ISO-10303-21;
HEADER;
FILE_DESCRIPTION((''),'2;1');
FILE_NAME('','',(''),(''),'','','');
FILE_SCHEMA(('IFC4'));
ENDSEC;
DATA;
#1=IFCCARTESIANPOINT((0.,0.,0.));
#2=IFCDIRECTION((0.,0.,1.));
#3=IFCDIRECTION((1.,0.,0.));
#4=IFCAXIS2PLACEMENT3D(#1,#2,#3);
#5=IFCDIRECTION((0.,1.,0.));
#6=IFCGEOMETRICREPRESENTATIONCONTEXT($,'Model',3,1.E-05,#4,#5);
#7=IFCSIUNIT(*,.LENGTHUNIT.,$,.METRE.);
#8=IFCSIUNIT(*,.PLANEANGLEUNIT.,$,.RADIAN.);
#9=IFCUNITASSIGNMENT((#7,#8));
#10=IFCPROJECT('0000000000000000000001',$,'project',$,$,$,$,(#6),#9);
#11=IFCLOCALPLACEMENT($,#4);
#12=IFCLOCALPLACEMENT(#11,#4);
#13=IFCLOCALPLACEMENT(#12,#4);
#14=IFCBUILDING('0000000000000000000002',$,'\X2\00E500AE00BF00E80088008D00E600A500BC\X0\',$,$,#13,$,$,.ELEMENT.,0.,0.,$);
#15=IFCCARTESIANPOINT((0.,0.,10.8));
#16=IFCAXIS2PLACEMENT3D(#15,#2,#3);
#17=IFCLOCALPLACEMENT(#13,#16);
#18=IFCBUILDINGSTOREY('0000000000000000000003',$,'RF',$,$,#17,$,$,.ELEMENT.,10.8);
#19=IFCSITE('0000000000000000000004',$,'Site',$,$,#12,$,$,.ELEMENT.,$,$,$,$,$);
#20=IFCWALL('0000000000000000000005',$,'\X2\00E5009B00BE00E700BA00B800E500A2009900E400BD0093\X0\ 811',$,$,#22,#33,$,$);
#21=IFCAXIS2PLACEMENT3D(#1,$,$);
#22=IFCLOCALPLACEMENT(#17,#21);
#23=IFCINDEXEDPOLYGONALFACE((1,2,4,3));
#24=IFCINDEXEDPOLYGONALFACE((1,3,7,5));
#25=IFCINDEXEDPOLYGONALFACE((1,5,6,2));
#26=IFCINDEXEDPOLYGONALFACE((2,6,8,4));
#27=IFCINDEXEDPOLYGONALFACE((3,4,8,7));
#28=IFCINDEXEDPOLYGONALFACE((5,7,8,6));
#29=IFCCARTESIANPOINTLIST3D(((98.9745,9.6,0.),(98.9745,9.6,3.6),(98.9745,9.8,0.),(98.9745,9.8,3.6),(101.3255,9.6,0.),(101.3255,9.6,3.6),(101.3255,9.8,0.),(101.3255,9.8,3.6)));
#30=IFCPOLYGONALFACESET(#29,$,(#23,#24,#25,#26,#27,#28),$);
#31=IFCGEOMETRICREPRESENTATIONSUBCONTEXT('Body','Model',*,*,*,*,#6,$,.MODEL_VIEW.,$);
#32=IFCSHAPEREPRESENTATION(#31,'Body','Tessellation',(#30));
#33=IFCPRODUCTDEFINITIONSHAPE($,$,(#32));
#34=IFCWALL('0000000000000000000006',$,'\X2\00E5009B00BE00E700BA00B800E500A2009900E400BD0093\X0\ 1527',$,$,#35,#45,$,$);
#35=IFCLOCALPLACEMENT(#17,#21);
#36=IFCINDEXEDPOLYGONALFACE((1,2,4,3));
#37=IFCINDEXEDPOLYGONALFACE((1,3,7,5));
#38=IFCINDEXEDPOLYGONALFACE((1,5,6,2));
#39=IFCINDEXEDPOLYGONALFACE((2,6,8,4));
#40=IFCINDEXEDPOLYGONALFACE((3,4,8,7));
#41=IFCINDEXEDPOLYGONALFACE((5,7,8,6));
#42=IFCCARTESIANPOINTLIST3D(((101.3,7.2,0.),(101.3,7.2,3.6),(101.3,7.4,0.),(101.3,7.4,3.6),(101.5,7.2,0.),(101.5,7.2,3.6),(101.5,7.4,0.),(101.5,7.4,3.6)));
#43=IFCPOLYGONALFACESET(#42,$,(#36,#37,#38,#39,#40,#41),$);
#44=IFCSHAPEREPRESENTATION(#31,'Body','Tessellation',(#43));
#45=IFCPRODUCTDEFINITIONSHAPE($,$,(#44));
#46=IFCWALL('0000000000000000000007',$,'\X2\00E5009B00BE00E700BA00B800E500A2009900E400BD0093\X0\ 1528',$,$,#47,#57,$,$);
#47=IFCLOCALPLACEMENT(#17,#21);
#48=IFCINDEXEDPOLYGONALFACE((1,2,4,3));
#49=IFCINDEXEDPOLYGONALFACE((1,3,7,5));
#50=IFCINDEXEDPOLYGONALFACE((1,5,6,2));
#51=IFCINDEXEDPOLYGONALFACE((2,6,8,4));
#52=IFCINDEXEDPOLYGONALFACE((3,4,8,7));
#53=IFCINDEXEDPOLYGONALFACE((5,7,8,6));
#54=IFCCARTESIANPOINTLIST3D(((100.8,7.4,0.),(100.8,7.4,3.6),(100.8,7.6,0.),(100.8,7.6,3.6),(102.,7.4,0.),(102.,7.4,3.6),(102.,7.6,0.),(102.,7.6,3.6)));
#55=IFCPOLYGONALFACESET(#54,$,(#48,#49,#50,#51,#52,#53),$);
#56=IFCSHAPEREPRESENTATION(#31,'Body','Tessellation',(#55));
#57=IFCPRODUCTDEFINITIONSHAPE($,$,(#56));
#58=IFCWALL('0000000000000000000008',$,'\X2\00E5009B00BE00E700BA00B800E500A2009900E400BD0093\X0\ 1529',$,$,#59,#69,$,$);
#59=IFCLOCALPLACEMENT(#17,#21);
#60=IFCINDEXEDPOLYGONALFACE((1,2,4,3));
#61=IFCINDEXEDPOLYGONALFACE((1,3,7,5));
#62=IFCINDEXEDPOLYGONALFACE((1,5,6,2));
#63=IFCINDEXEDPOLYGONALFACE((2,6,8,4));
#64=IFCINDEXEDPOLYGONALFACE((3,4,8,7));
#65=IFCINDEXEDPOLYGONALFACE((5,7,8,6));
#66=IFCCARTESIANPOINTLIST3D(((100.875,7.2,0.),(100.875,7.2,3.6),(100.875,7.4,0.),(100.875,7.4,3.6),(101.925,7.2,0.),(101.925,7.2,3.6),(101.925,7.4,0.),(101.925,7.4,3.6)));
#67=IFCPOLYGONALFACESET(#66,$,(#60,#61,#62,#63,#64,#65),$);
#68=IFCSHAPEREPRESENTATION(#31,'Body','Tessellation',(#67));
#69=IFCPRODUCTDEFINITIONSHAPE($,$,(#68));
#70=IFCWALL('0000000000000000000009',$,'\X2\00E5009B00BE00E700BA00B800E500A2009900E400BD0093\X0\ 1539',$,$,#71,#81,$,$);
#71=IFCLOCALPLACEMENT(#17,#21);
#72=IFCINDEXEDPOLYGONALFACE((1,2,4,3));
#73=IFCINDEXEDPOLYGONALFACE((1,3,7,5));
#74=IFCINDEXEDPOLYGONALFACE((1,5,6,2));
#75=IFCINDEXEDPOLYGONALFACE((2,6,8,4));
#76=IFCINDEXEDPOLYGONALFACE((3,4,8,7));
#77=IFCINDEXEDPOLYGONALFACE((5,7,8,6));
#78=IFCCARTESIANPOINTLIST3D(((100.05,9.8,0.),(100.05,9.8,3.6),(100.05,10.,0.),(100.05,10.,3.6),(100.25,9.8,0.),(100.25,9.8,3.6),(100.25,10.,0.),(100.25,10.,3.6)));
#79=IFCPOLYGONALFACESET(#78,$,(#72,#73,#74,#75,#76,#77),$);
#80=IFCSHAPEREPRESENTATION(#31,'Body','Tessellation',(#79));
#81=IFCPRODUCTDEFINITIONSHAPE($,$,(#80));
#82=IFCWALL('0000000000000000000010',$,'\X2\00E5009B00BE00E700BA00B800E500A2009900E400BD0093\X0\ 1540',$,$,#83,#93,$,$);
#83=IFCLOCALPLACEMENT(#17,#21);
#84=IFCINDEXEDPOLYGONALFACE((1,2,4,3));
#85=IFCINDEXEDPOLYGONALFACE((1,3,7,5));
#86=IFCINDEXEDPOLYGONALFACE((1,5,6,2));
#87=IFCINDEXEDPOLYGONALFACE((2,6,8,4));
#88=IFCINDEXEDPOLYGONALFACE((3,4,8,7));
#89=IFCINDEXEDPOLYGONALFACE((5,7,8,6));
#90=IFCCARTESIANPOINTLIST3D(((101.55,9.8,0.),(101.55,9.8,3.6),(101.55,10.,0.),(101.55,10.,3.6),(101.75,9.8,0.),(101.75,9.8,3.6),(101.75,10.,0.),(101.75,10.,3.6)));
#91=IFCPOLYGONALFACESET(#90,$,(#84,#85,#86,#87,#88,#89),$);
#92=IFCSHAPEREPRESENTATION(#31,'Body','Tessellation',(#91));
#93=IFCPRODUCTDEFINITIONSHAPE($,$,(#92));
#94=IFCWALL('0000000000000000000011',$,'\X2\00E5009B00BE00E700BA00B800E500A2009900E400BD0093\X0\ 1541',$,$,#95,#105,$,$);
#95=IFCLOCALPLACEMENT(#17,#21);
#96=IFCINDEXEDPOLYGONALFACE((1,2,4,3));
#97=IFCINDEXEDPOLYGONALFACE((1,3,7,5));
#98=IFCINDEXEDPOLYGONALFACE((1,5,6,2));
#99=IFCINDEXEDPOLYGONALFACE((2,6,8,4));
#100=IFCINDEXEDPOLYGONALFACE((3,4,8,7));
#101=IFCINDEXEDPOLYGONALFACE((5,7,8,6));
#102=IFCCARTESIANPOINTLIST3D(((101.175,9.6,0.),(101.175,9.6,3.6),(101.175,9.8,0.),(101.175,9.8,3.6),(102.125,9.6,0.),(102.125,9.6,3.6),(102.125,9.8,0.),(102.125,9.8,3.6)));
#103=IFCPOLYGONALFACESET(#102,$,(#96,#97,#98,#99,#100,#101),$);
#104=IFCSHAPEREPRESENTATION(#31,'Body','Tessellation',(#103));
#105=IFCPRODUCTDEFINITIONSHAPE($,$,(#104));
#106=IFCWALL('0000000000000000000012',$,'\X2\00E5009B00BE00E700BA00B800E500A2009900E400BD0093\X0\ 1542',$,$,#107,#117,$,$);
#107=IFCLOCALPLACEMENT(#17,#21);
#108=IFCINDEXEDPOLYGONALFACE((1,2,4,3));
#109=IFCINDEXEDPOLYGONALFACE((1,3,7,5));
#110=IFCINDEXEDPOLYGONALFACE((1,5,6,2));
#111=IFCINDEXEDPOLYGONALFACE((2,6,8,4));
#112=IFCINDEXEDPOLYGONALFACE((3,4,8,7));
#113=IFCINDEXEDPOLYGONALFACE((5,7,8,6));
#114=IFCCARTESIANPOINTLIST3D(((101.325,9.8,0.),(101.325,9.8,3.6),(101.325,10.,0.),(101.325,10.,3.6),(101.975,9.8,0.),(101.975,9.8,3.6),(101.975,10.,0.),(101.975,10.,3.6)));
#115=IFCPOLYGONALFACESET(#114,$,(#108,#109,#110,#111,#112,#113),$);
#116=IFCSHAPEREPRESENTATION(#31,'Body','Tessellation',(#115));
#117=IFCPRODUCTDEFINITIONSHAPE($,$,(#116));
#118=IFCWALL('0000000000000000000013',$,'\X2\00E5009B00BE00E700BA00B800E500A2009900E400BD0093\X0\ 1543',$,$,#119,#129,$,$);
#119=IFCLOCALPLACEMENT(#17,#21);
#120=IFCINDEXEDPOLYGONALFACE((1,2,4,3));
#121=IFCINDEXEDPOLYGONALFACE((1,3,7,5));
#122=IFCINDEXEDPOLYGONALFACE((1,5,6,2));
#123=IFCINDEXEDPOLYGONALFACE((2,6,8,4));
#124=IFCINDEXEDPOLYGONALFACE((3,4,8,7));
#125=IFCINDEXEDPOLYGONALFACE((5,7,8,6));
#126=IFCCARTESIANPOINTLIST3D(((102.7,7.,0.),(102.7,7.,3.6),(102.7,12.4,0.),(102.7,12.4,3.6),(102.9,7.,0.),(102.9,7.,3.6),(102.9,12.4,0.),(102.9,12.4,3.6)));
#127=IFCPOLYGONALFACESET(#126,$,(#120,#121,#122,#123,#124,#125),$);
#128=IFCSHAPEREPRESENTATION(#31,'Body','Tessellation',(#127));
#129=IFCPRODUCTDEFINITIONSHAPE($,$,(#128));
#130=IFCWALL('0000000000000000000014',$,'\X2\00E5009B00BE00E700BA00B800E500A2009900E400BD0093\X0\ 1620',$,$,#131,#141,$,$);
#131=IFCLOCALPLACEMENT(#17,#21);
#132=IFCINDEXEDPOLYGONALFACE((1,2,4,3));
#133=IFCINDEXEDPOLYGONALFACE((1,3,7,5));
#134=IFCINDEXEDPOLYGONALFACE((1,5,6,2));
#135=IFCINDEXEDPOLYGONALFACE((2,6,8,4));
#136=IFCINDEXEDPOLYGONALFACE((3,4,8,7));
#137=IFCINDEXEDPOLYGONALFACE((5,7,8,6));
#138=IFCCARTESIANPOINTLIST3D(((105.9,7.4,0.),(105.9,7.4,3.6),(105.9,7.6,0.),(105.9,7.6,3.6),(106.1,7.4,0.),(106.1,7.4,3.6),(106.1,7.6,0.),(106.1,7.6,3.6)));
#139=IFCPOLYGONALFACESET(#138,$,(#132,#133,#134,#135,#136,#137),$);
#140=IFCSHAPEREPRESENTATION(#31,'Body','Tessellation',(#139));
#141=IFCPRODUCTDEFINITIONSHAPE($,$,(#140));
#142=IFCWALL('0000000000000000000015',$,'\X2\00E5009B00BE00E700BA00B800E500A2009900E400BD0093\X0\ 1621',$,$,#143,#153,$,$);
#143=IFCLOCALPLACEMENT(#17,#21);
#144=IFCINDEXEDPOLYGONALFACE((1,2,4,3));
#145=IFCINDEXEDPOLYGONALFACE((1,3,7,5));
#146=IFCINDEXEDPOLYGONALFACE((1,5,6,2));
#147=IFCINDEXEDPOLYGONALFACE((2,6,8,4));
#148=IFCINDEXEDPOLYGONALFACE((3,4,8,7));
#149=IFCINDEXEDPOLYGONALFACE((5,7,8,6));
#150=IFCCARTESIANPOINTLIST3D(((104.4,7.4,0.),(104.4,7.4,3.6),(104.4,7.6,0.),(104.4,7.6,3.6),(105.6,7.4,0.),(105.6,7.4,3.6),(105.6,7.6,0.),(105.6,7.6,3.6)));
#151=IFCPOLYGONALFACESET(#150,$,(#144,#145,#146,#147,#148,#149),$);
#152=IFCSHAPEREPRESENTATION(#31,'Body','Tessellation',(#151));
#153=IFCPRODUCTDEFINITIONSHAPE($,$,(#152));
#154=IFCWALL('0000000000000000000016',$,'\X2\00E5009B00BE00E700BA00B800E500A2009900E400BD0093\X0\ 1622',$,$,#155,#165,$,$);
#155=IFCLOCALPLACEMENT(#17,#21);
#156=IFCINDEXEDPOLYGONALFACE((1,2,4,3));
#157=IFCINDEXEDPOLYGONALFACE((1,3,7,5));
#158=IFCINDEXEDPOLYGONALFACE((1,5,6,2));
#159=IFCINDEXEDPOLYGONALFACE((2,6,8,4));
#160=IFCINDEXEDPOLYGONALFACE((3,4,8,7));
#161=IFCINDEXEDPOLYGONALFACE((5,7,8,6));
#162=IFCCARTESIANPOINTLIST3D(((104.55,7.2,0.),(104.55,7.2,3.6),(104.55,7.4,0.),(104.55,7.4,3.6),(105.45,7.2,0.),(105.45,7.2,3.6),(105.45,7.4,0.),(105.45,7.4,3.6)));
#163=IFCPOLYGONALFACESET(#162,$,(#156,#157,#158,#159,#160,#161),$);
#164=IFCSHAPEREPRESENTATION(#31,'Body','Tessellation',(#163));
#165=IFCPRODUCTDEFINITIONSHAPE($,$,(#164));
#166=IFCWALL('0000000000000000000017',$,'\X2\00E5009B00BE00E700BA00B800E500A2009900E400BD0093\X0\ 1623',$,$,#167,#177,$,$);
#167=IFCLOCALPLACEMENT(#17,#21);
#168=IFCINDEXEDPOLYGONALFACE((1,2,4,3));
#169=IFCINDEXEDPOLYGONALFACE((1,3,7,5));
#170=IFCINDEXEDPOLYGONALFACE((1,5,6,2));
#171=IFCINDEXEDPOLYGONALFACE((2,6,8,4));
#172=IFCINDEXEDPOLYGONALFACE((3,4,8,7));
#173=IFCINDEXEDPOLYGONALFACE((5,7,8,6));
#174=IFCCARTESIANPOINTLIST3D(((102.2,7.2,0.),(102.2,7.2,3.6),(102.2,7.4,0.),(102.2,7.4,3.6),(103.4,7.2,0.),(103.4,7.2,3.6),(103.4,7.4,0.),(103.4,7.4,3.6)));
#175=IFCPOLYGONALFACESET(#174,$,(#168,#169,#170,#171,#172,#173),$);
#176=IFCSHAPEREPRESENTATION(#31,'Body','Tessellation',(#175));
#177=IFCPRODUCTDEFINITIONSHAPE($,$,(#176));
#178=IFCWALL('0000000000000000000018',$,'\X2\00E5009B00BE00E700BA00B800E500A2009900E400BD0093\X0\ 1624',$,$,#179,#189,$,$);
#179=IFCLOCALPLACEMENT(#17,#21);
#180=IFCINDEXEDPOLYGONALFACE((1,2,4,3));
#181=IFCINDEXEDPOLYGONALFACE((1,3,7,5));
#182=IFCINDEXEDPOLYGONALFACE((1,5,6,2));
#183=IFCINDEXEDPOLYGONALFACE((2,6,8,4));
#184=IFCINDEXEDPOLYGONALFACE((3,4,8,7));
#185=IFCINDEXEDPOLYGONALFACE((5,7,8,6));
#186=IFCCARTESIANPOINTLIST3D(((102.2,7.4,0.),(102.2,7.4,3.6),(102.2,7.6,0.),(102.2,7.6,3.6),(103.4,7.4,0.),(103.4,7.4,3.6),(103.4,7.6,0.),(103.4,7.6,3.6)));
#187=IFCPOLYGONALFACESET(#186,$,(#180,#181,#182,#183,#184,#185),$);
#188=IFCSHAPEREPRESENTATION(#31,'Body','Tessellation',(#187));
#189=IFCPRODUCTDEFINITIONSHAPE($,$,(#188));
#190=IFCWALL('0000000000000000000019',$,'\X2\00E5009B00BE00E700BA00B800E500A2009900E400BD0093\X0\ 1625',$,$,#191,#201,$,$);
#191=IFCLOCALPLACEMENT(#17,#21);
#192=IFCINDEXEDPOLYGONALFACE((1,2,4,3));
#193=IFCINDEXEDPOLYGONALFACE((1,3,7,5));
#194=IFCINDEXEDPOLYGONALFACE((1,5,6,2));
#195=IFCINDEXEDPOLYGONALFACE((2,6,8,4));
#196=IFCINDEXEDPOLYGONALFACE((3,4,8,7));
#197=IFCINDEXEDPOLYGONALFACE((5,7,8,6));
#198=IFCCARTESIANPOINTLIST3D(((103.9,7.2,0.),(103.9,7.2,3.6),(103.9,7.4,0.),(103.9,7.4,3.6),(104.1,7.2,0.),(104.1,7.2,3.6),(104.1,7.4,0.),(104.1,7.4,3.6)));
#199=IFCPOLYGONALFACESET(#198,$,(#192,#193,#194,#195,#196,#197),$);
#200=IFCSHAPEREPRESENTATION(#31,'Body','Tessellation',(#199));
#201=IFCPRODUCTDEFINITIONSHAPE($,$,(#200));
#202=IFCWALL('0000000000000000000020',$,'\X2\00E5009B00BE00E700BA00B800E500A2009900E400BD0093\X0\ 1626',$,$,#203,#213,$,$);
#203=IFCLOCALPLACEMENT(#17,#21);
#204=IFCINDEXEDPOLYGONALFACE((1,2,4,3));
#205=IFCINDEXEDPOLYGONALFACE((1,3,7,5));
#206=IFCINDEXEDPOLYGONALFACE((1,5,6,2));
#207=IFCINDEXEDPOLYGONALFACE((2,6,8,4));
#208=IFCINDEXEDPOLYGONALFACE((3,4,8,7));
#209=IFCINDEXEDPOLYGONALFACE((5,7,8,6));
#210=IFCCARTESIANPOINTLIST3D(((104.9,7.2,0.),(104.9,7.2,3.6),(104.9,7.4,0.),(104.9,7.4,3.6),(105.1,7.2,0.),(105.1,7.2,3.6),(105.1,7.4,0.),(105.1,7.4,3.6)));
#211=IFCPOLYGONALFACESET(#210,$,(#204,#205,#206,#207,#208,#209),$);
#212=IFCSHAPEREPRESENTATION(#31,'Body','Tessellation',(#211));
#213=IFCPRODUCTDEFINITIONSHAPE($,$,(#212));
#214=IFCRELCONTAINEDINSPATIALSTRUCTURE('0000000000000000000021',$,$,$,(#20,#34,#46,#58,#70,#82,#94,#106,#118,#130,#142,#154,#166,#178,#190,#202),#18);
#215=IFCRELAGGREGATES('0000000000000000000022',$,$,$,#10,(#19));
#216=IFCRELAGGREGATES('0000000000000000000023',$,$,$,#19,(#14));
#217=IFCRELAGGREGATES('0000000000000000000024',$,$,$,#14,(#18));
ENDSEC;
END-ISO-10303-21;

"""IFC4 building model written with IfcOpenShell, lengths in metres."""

from ifc_helpers import new_model, si_unit, direction, frame, frame_2d, origin_with_axes, place, context, subcontext, project, spatial, rectangle, extrude, element, save


model = new_model("IFC4")

# Units and contexts
model_context = context("Model", 3, precision=1e-05, world=origin_with_axes(), true_north=direction((0.0, 1.0, 0.0)))
body_context = subcontext(model_context, "Body", "Model", "MODEL_VIEW")
ifc_project = project(units=[si_unit("LENGTHUNIT", "METRE"), si_unit("PLANEANGLEUNIT", "RADIAN")], contexts=[model_context])

# Site, building, storey
placement = place(None, origin_with_axes())
site_placement = place(placement, origin_with_axes())
site = spatial("IfcSite", under=ifc_project, at=site_placement, Name="Site", CompositionType="ELEMENT")
building_placement = place(site_placement, origin_with_axes())
building = spatial("IfcBuilding", under=site, at=building_placement, Name="å®¿è\u0088\u008dæ¥¼", CompositionType="ELEMENT", ElevationOfRefHeight=0.0, ElevationOfTerrain=0.0)
storey_placement = place(building_placement, frame((0.0, 0.0, 10.8), z_axis=(0.0, 0.0, 1.0), x_axis=(1.0, 0.0, 0.0)))
storey = spatial("IfcBuildingStorey", under=building, at=storey_placement, Name="RF", CompositionType="ELEMENT", Elevation=10.8)

# Walls
wall_1_placement = place(storey_placement, frame((100.15, 9.7, 0.0), z_axis=(0.0, 0.0, 1.0), x_axis=(-1.0, 0.0, 0.0)))
element("IfcWall", 1, at=wall_1_placement, inside=storey, Name="å\u009b¾çº¸å¢\u0099ä½\u0093 811", context=body_context, shape_type="SweptSolid", body=[
    extrude(rectangle(XDim=2.351, YDim=0.2, at=frame_2d((0.0, 0.0), x_axis=(1.0, 0.0, 0.0))), frame((0.0, 0.0, 0.0), z_axis=(0.0, 0.0, 1.0)), (0.0, 0.0, 1.0), 3.6),
])
wall_2_placement = place(storey_placement, frame((101.4, 7.3, 0.0), z_axis=(0.0, 0.0, 1.0), x_axis=(0.0, 1.0, 0.0)))
element("IfcWall", 2, at=wall_2_placement, inside=storey, Name="å\u009b¾çº¸å¢\u0099ä½\u0093 1527", context=body_context, shape_type="SweptSolid", body=[
    extrude(rectangle(XDim=0.2, YDim=0.2, at=frame_2d((0.0, 0.0), x_axis=(1.0, 0.0, 0.0))), frame((0.0, 0.0, 0.0), z_axis=(0.0, 0.0, 1.0)), (0.0, 0.0, 1.0), 3.6),
])
wall_3_placement = place(storey_placement, frame((101.4, 7.5, 0.0), z_axis=(0.0, 0.0, 1.0), x_axis=(1.0, 0.0, 0.0)))
element("IfcWall", 3, at=wall_3_placement, inside=storey, Name="å\u009b¾çº¸å¢\u0099ä½\u0093 1528", context=body_context, shape_type="SweptSolid", body=[
    extrude(rectangle(XDim=1.2, YDim=0.2, at=frame_2d((0.0, 0.0), x_axis=(1.0, 0.0, 0.0))), frame((0.0, 0.0, 0.0), z_axis=(0.0, 0.0, 1.0)), (0.0, 0.0, 1.0), 3.6),
])
wall_4_placement = place(storey_placement, frame((101.4, 7.3, 0.0), z_axis=(0.0, 0.0, 1.0), x_axis=(1.0, 0.0, 0.0)))
element("IfcWall", 4, at=wall_4_placement, inside=storey, Name="å\u009b¾çº¸å¢\u0099ä½\u0093 1529", context=body_context, shape_type="SweptSolid", body=[
    extrude(rectangle(XDim=1.05, YDim=0.2, at=frame_2d((0.0, 0.0), x_axis=(1.0, 0.0, 0.0))), frame((0.0, 0.0, 0.0), z_axis=(0.0, 0.0, 1.0)), (0.0, 0.0, 1.0), 3.6),
])
for number, where, z_axis, x_axis, name in (
    (5, (100.15, 9.9, 0.0), (0.0, 0.0, 1.0), (0.0, -1.0, 0.0), "å\u009b¾çº¸å¢\u0099ä½\u0093 1539"),
    (6, (101.65, 9.9, 0.0), (0.0, 0.0, 1.0), (0.0, -1.0, 0.0), "å\u009b¾çº¸å¢\u0099ä½\u0093 1540"),
):
    element("IfcWall", number, at=place(storey_placement, frame(where, z_axis=z_axis, x_axis=x_axis)), inside=storey, Name=name, context=body_context, shape_type="SweptSolid", body=[
        extrude(rectangle(XDim=0.2, YDim=0.2, at=frame_2d((0.0, 0.0), x_axis=(1.0, 0.0, 0.0))), frame((0.0, 0.0, 0.0), z_axis=(0.0, 0.0, 1.0)), (0.0, 0.0, 1.0), 3.6),
    ])
wall_5_placement = place(storey_placement, frame((101.65, 9.7, 0.0), z_axis=(0.0, 0.0, 1.0), x_axis=(1.0, 0.0, 0.0)))
element("IfcWall", 7, at=wall_5_placement, inside=storey, Name="å\u009b¾çº¸å¢\u0099ä½\u0093 1541", context=body_context, shape_type="SweptSolid", body=[
    extrude(rectangle(XDim=0.95, YDim=0.2, at=frame_2d((0.0, 0.0), x_axis=(1.0, 0.0, 0.0))), frame((0.0, 0.0, 0.0), z_axis=(0.0, 0.0, 1.0)), (0.0, 0.0, 1.0), 3.6),
])
wall_6_placement = place(storey_placement, frame((101.65, 9.9, 0.0), z_axis=(0.0, 0.0, 1.0), x_axis=(1.0, 0.0, 0.0)))
element("IfcWall", 8, at=wall_6_placement, inside=storey, Name="å\u009b¾çº¸å¢\u0099ä½\u0093 1542", context=body_context, shape_type="SweptSolid", body=[
    extrude(rectangle(XDim=0.65, YDim=0.2, at=frame_2d((0.0, 0.0), x_axis=(1.0, 0.0, 0.0))), frame((0.0, 0.0, 0.0), z_axis=(0.0, 0.0, 1.0)), (0.0, 0.0, 1.0), 3.6),
])
wall_7_placement = place(storey_placement, frame((102.8, 9.7, 0.0), z_axis=(0.0, 0.0, 1.0), x_axis=(0.0, 1.0, 0.0)))
element("IfcWall", 9, at=wall_7_placement, inside=storey, Name="å\u009b¾çº¸å¢\u0099ä½\u0093 1543", context=body_context, shape_type="SweptSolid", body=[
    extrude(rectangle(XDim=5.4, YDim=0.2, at=frame_2d((0.0, 0.0), x_axis=(1.0, 0.0, 0.0))), frame((0.0, 0.0, 0.0), z_axis=(0.0, 0.0, 1.0)), (0.0, 0.0, 1.0), 3.6),
])
wall_8_placement = place(storey_placement, frame((106.0, 7.5, 0.0), z_axis=(0.0, 0.0, 1.0), x_axis=(-1.0, 0.0, 0.0)))
element("IfcWall", 10, at=wall_8_placement, inside=storey, Name="å\u009b¾çº¸å¢\u0099ä½\u0093 1620", context=body_context, shape_type="SweptSolid", body=[
    extrude(rectangle(XDim=0.2, YDim=0.2, at=frame_2d((0.0, 0.0), x_axis=(1.0, 0.0, 0.0))), frame((0.0, 0.0, 0.0), z_axis=(0.0, 0.0, 1.0)), (0.0, 0.0, 1.0), 3.6),
])
wall_9_placement = place(storey_placement, frame((105.0, 7.5, 0.0), z_axis=(0.0, 0.0, 1.0), x_axis=(1.0, 0.0, 0.0)))
element("IfcWall", 11, at=wall_9_placement, inside=storey, Name="å\u009b¾çº¸å¢\u0099ä½\u0093 1621", context=body_context, shape_type="SweptSolid", body=[
    extrude(rectangle(XDim=1.2, YDim=0.2, at=frame_2d((0.0, 0.0), x_axis=(1.0, 0.0, 0.0))), frame((0.0, 0.0, 0.0), z_axis=(0.0, 0.0, 1.0)), (0.0, 0.0, 1.0), 3.6),
])
wall_10_placement = place(storey_placement, frame((105.0, 7.3, 0.0), z_axis=(0.0, 0.0, 1.0), x_axis=(1.0, 0.0, 0.0)))
element("IfcWall", 12, at=wall_10_placement, inside=storey, Name="å\u009b¾çº¸å¢\u0099ä½\u0093 1622", context=body_context, shape_type="SweptSolid", body=[
    extrude(rectangle(XDim=0.9, YDim=0.2, at=frame_2d((0.0, 0.0), x_axis=(1.0, 0.0, 0.0))), frame((0.0, 0.0, 0.0), z_axis=(0.0, 0.0, 1.0)), (0.0, 0.0, 1.0), 3.6),
])
for number, where, z_axis, x_axis, name in (
    (13, (102.8, 7.3, 0.0), (0.0, 0.0, 1.0), (1.0, 0.0, 0.0), "å\u009b¾çº¸å¢\u0099ä½\u0093 1623"),
    (14, (102.8, 7.5, 0.0), (0.0, 0.0, 1.0), (1.0, 0.0, 0.0), "å\u009b¾çº¸å¢\u0099ä½\u0093 1624"),
):
    element("IfcWall", number, at=place(storey_placement, frame(where, z_axis=z_axis, x_axis=x_axis)), inside=storey, Name=name, context=body_context, shape_type="SweptSolid", body=[
        extrude(rectangle(XDim=1.2, YDim=0.2, at=frame_2d((0.0, 0.0), x_axis=(1.0, 0.0, 0.0))), frame((0.0, 0.0, 0.0), z_axis=(0.0, 0.0, 1.0)), (0.0, 0.0, 1.0), 3.6),
    ])
for number, where, z_axis, x_axis, name in (
    (15, (104.0, 7.3, 0.0), (0.0, 0.0, 1.0), (0.0, 1.0, 0.0), "å\u009b¾çº¸å¢\u0099ä½\u0093 1625"),
    (16, (105.0, 7.3, 0.0), (0.0, 0.0, 1.0), (0.0, 1.0, 0.0), "å\u009b¾çº¸å¢\u0099ä½\u0093 1626"),
):
    element("IfcWall", number, at=place(storey_placement, frame(where, z_axis=z_axis, x_axis=x_axis)), inside=storey, Name=name, context=body_context, shape_type="SweptSolid", body=[
        extrude(rectangle(XDim=0.2, YDim=0.2, at=frame_2d((0.0, 0.0), x_axis=(1.0, 0.0, 0.0))), frame((0.0, 0.0, 0.0), z_axis=(0.0, 0.0, 1.0)), (0.0, 0.0, 1.0), 3.6),
    ])

save(model, "model.ifc")
